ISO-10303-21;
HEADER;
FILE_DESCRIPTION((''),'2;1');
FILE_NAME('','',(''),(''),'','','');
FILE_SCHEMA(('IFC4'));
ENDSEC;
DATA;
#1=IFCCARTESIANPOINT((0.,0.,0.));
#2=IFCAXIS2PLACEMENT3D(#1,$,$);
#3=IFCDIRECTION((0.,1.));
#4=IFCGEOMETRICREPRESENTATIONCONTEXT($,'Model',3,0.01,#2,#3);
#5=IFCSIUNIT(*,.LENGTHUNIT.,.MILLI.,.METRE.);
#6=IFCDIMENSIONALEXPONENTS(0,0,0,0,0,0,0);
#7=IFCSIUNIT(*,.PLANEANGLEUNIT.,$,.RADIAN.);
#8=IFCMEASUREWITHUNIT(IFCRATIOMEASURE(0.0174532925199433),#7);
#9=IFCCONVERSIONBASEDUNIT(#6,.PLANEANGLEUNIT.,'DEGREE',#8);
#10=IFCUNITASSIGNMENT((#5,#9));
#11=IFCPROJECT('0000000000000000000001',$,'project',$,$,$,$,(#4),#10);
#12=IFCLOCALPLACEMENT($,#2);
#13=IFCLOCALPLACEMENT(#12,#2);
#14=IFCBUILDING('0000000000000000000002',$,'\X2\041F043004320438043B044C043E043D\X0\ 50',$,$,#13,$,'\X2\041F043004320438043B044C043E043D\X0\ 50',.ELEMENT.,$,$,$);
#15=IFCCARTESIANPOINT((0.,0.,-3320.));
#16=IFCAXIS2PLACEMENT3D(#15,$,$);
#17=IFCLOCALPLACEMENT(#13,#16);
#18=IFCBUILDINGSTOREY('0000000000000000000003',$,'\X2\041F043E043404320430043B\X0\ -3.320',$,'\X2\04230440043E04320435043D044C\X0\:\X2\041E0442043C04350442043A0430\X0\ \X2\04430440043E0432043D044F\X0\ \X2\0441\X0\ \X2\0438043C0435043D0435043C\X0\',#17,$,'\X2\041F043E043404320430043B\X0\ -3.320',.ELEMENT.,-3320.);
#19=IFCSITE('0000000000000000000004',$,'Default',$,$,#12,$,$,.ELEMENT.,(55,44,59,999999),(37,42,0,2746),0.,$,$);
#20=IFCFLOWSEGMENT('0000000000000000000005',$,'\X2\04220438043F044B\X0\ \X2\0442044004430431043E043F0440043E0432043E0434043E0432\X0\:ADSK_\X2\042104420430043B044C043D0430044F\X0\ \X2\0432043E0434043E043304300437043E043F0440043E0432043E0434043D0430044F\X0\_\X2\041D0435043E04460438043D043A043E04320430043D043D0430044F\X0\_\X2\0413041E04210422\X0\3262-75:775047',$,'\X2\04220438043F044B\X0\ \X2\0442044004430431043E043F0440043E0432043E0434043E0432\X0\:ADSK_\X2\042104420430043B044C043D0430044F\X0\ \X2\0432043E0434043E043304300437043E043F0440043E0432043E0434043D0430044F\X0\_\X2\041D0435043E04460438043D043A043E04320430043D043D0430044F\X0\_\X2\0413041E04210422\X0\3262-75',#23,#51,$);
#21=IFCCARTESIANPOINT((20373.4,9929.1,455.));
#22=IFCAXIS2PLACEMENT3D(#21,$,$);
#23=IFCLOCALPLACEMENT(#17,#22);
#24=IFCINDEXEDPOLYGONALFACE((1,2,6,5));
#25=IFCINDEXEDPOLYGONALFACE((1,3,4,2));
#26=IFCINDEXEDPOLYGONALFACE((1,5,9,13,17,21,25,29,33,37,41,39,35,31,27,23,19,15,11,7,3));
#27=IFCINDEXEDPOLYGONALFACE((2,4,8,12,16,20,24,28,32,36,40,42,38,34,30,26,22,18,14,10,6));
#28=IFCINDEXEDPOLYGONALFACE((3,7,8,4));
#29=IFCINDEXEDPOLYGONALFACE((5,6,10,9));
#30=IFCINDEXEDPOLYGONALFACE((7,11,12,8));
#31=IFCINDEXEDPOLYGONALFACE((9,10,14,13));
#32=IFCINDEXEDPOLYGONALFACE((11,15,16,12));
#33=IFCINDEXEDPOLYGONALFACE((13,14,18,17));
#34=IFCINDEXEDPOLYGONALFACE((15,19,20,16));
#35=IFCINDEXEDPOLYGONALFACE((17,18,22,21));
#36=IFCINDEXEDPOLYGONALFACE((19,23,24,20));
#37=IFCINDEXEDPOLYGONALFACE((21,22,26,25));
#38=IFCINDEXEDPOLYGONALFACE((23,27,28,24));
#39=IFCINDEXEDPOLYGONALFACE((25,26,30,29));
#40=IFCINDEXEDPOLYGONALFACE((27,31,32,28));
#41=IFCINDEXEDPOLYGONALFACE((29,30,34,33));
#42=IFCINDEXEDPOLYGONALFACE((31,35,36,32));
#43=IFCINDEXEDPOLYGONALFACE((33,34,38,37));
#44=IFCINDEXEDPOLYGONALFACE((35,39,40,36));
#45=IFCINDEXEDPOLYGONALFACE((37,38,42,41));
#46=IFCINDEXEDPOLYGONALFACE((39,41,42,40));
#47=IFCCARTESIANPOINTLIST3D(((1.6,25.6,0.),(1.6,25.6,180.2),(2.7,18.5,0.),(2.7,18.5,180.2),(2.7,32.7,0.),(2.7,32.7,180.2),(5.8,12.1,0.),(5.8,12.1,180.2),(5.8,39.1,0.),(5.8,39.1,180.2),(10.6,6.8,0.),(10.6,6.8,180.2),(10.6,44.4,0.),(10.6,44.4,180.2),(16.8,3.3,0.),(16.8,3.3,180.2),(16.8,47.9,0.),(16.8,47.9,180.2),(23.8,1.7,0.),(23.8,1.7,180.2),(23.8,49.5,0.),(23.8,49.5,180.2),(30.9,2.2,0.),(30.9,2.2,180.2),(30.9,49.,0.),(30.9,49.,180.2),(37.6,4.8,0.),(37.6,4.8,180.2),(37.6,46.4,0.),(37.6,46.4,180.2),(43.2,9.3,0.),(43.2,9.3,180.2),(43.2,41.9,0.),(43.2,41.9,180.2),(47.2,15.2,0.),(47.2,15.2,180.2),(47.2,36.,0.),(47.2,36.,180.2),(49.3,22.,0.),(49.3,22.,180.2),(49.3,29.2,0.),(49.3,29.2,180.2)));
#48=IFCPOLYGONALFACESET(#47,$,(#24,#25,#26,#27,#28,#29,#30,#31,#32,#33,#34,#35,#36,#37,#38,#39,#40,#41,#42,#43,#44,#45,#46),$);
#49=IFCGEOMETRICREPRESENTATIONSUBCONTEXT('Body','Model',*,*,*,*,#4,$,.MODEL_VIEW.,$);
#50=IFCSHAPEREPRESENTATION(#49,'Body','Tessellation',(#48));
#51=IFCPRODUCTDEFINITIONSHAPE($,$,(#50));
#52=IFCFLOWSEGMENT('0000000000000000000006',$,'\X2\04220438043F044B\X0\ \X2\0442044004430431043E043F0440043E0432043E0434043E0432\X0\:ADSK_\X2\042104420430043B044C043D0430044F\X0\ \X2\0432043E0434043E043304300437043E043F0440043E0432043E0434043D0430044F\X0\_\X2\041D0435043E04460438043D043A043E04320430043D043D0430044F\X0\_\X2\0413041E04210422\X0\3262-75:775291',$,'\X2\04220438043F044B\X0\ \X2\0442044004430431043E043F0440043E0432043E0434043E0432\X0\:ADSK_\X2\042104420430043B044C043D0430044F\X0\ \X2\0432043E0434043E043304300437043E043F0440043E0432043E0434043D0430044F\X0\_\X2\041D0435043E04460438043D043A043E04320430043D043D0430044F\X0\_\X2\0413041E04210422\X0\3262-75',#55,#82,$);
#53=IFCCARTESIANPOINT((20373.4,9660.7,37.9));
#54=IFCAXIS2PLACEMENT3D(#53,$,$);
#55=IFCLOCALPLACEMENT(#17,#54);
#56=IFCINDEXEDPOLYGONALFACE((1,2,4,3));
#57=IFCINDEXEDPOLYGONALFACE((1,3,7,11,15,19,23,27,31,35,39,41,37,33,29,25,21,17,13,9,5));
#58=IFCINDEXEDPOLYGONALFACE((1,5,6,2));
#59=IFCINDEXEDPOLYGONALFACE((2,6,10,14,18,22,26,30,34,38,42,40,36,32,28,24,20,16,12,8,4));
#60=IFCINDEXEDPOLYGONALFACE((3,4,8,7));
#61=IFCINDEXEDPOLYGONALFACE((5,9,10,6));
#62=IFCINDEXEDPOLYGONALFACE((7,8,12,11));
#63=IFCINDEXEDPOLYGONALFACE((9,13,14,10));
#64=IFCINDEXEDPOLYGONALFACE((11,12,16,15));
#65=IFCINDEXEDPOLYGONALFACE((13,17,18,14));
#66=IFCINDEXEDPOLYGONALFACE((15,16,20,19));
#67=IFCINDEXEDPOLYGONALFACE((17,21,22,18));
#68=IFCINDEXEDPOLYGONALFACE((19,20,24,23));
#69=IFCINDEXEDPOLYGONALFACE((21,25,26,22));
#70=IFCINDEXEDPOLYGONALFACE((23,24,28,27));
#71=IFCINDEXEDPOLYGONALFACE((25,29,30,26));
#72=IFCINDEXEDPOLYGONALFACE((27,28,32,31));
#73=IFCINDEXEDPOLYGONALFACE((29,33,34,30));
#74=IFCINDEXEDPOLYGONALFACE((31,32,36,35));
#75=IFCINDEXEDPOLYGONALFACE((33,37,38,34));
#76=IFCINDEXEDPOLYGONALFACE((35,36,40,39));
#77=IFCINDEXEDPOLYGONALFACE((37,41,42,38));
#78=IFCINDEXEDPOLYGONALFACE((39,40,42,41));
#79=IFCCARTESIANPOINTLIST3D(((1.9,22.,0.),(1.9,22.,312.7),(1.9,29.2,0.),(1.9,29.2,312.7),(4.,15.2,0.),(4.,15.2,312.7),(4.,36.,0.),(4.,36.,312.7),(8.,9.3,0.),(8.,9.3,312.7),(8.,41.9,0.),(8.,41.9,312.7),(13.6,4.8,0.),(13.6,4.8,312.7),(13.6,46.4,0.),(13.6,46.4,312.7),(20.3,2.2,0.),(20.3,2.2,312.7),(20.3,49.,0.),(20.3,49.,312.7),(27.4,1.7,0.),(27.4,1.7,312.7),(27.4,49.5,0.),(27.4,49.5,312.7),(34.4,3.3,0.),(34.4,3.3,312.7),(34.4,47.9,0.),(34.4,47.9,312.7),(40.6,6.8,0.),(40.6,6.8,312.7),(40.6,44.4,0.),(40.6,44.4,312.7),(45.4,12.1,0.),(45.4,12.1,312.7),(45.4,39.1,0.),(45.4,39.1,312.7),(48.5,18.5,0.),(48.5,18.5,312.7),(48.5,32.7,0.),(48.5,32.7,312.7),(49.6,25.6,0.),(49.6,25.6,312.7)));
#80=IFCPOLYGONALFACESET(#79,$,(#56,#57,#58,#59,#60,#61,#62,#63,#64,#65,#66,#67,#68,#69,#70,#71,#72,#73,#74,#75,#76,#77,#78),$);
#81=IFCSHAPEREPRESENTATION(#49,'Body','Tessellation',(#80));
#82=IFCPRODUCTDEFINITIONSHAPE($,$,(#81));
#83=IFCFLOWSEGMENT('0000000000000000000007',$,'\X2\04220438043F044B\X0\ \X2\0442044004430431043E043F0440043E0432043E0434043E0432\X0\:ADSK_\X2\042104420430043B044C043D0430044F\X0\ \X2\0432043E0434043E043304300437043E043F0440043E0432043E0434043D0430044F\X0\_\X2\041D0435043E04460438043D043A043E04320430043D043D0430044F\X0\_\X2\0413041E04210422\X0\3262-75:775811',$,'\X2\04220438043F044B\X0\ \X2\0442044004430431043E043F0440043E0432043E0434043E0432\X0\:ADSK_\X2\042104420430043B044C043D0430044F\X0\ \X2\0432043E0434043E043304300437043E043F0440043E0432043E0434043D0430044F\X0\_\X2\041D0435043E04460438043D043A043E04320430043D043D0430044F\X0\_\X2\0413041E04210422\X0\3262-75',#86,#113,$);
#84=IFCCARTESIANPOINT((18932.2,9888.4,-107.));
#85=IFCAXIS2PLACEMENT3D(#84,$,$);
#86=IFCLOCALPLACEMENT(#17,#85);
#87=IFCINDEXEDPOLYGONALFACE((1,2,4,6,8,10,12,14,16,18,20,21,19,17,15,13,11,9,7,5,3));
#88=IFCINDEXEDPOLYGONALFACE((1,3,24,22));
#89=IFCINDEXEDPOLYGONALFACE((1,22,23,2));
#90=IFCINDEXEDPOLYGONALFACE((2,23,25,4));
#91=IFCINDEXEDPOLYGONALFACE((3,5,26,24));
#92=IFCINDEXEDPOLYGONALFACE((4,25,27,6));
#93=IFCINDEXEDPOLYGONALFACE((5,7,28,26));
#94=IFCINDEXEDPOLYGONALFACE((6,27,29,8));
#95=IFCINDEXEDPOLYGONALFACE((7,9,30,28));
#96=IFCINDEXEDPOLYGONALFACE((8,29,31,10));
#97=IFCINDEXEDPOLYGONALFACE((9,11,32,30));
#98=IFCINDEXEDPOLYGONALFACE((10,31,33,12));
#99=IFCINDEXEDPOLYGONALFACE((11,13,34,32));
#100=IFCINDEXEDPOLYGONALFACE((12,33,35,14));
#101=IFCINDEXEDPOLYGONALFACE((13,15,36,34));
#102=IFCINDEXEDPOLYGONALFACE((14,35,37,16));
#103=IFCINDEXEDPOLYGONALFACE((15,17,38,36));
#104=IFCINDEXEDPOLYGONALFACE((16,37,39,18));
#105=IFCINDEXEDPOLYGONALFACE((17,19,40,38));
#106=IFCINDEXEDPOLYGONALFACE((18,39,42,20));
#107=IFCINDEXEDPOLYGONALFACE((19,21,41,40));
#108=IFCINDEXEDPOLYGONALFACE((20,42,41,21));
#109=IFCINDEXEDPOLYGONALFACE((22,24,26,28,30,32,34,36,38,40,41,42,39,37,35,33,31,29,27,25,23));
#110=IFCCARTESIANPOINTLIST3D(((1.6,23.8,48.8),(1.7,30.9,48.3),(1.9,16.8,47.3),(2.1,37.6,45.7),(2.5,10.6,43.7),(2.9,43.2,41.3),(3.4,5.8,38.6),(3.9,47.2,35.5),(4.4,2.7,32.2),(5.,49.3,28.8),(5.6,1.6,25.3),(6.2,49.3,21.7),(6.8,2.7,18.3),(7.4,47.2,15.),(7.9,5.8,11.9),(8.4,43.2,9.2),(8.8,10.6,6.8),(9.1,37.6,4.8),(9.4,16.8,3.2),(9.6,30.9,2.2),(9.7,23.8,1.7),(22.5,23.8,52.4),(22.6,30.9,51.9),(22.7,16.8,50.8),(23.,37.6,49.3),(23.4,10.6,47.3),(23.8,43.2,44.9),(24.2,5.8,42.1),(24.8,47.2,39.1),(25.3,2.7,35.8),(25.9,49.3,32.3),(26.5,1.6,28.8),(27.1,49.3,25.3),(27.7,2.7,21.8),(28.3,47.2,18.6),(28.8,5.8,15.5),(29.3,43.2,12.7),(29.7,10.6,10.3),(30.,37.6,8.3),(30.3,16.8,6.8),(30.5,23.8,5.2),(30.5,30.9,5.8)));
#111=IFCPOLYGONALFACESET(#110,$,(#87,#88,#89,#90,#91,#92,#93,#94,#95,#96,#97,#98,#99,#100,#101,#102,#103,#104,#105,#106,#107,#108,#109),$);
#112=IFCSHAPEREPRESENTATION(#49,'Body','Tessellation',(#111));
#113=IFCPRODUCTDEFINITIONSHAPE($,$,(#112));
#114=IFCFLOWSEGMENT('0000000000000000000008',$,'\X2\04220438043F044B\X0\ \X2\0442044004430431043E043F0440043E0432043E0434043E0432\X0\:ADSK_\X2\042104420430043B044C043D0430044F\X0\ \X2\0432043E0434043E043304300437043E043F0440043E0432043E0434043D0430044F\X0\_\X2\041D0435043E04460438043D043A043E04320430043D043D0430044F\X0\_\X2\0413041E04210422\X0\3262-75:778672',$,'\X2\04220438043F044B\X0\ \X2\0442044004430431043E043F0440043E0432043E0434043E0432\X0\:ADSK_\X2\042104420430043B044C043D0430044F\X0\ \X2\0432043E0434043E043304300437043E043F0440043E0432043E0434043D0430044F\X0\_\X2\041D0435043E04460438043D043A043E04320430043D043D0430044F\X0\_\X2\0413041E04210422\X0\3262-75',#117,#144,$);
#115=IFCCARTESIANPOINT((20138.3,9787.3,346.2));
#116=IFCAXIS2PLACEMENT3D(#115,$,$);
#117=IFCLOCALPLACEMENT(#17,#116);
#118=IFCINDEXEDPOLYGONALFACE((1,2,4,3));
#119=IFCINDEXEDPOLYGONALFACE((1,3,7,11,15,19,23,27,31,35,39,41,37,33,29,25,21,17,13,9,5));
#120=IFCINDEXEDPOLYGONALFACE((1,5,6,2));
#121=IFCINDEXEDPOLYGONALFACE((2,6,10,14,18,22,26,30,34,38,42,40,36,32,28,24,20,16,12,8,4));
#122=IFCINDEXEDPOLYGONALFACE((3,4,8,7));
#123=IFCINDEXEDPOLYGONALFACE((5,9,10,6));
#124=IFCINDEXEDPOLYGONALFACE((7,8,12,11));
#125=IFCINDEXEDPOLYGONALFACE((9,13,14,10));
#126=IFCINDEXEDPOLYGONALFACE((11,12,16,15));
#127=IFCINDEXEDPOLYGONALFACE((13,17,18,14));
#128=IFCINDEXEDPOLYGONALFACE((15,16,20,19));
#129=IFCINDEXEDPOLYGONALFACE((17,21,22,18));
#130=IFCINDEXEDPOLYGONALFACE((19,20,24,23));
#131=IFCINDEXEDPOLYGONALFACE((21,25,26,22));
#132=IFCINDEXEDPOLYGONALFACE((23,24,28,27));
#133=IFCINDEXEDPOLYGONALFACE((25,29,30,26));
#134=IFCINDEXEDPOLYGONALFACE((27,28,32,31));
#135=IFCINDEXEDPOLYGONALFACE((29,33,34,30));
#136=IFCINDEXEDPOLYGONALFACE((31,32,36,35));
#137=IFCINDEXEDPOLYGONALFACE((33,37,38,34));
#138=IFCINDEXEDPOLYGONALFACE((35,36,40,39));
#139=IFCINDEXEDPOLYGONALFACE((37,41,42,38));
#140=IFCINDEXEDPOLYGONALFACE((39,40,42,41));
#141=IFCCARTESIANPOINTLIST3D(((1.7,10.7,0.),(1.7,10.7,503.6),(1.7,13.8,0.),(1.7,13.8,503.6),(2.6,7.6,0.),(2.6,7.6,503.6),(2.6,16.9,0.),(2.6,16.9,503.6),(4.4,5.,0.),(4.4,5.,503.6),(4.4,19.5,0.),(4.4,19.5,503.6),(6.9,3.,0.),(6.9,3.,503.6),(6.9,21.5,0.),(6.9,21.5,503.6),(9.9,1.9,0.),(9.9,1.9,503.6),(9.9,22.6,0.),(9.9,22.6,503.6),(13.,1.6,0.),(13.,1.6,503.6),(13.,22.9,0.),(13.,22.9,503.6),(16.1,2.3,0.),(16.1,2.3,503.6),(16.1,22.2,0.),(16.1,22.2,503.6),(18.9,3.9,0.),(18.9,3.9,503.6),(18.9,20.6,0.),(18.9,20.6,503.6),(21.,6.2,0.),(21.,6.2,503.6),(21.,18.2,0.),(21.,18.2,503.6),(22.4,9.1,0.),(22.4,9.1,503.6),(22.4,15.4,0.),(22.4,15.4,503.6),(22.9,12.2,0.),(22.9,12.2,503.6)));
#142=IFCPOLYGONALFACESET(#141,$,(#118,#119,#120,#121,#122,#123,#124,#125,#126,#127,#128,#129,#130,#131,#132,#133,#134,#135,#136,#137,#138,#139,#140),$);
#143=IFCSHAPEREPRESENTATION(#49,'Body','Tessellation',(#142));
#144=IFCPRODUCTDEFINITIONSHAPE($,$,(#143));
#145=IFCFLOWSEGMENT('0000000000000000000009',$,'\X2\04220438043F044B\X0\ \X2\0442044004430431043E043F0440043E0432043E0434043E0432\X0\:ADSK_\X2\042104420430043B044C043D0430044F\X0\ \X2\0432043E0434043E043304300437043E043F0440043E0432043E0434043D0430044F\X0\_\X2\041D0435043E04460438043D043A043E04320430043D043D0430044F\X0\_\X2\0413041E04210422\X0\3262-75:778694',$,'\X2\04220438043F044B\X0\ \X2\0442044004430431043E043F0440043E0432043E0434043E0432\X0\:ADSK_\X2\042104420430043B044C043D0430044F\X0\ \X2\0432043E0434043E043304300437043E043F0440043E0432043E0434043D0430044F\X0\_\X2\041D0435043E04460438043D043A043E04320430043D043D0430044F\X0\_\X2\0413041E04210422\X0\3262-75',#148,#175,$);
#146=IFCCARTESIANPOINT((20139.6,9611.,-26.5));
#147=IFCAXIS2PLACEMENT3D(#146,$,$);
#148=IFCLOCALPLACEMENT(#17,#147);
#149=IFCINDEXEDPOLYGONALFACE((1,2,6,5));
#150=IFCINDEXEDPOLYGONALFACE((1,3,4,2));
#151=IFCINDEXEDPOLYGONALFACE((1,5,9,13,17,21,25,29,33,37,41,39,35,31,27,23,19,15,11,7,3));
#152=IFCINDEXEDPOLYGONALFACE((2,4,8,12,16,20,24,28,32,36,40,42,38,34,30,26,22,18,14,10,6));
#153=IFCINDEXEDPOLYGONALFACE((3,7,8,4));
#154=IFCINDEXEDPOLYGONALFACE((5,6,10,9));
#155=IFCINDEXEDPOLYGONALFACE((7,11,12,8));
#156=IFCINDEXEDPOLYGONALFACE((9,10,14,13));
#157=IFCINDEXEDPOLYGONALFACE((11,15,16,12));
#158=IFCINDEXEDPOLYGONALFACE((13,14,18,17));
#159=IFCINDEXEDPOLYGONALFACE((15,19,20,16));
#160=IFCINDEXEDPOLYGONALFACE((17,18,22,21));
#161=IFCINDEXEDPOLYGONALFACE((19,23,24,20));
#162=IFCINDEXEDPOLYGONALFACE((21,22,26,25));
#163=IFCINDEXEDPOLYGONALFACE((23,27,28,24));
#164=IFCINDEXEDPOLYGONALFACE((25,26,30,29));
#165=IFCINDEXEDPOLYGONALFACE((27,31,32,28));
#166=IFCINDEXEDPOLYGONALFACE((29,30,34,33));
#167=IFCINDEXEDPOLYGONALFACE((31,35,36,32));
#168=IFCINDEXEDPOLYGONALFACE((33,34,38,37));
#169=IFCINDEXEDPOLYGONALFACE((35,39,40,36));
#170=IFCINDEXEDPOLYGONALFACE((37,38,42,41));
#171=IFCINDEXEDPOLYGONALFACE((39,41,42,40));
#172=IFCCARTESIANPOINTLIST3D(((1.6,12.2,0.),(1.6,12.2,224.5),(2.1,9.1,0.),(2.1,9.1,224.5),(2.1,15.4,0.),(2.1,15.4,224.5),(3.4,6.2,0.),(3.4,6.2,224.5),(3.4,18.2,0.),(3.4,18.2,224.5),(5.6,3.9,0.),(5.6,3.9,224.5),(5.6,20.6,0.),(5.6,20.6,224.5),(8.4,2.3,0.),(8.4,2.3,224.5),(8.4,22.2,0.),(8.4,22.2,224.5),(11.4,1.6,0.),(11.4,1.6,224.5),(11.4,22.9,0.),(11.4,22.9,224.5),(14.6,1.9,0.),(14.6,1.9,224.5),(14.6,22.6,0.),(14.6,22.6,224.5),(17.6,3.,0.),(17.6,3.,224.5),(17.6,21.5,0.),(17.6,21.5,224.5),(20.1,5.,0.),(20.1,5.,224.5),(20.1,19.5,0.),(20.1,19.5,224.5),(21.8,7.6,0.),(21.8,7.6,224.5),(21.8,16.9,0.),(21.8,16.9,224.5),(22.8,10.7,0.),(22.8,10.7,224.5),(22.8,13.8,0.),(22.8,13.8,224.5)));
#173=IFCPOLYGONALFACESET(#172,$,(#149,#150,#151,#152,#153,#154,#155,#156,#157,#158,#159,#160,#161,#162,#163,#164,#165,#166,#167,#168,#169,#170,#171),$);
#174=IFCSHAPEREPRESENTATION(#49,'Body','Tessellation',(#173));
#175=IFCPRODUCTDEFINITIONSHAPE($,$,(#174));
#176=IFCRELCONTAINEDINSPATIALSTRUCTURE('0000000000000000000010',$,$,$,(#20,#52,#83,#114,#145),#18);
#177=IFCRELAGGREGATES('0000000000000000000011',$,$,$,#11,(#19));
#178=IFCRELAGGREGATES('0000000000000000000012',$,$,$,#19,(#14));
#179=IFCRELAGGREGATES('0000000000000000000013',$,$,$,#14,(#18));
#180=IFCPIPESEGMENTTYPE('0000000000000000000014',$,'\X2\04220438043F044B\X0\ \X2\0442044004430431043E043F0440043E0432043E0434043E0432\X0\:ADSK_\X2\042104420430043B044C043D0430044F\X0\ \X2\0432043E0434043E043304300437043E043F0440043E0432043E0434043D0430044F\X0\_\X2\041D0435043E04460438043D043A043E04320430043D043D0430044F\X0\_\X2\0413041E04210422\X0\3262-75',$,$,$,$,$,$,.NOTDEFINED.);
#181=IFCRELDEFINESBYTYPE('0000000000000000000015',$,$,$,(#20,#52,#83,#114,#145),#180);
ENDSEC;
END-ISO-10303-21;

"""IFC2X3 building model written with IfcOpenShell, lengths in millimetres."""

from ifc_helpers import new_model, entity, si_unit, converted_unit, direction, frame, frame_2d, origin, origin_2d_with_axis, place, context, subcontext, project, spatial, circle, extrude, type_object, element, save


model = new_model("IFC2X3")

# Units and contexts
model_context = context("Model", 3, precision=0.01, world=origin(), true_north=direction((0.0, 1.0)))
body_context = subcontext(model_context, "Body", "Model", "MODEL_VIEW")
ifc_project = project(units=[si_unit("LENGTHUNIT", "METRE", prefix="MILLI"), converted_unit("PLANEANGLEUNIT", "DEGREE", entity("IfcRatioMeasure", 0.0174532925199433), si_unit("PLANEANGLEUNIT", "RADIAN"), dimensions=[0, 0, 0, 0, 0, 0, 0])], contexts=[model_context])

# Site, building, storey
site_placement = place(None, origin())
site = spatial("IfcSite", under=ifc_project, at=site_placement, Name="Default", CompositionType="ELEMENT", RefLatitude=(55, 44, 59, 999999), RefLongitude=(37, 42, 0, 2746), RefElevation=0.0)
building_placement = place(site_placement, origin())
building = spatial("IfcBuilding", under=site, at=building_placement, Name="Павильон 50", LongName="Павильон 50", CompositionType="ELEMENT")
storey_placement = place(building_placement, frame((0.0, 0.0, -3320.0)))
storey = spatial("IfcBuildingStorey", under=building, at=storey_placement, Name="Подвал -3.320", ObjectType="Уровень:Отметка уровня с именем", LongName="Подвал -3.320", CompositionType="ELEMENT", Elevation=-3320.0)

# Flow segments
pipe_segment_type = type_object("IfcPipeSegmentType", Name="Типы трубопроводов:ADSK_Стальная водогазопроводная_Неоцинкованная_ГОСТ3262-75", PredefinedType="NOTDEFINED")
flow_segment_1_placement = place(storey_placement, frame((20373.4, 9929.1, 455.0)))
element("IfcFlowSegment", 1, at=flow_segment_1_placement, inside=storey, type_object=pipe_segment_type, Name="Типы трубопроводов:ADSK_Стальная водогазопроводная_Неоцинкованная_ГОСТ3262-75:775047", ObjectType="Типы трубопроводов:ADSK_Стальная водогазопроводная_Неоцинкованная_ГОСТ3262-75", context=body_context, shape_type="SweptSolid", body=[
    extrude(circle(Radius=24.0, at=origin_2d_with_axis()), frame((25.6, 25.6, 0.0), z_axis=(0.0, 0.0, 1.0), x_axis=(-1.0, 0.0, 0.0)), (0.0, 0.0, 1.0), 180.2),
])
flow_segment_2_placement = place(storey_placement, frame((20373.4, 9660.7, 37.9)))
element("IfcFlowSegment", 2, at=flow_segment_2_placement, inside=storey, type_object=pipe_segment_type, Name="Типы трубопроводов:ADSK_Стальная водогазопроводная_Неоцинкованная_ГОСТ3262-75:775291", ObjectType="Типы трубопроводов:ADSK_Стальная водогазопроводная_Неоцинкованная_ГОСТ3262-75", context=body_context, shape_type="SweptSolid", body=[
    extrude(circle(Radius=24.0, at=origin_2d_with_axis()), frame((25.6, 25.6, 0.0)), (0.0, 0.0, 1.0), 312.7),
])
flow_segment_3_placement = place(storey_placement, frame((18932.2, 9888.4, -107.0)))
element("IfcFlowSegment", 3, at=flow_segment_3_placement, inside=storey, type_object=pipe_segment_type, Name="Типы трубопроводов:ADSK_Стальная водогазопроводная_Неоцинкованная_ГОСТ3262-75:775811", ObjectType="Типы трубопроводов:ADSK_Стальная водогазопроводная_Неоцинкованная_ГОСТ3262-75", context=body_context, shape_type="SweptSolid", body=[
    extrude(circle(Radius=24.0, at=frame_2d((0.0, 0.0), x_axis=(1.0, 0.0))), frame((5.6, 25.6, 25.3), z_axis=(0.985692, 0.0, 0.168556), x_axis=(0.0, -1.0, 0.0)), (0.0, 0.0, 1.0), 21.2),
])
flow_segment_4_placement = place(storey_placement, frame((20138.3, 9787.3, 346.2)))
element("IfcFlowSegment", 4, at=flow_segment_4_placement, inside=storey, type_object=pipe_segment_type, Name="Типы трубопроводов:ADSK_Стальная водогазопроводная_Неоцинкованная_ГОСТ3262-75:778672", ObjectType="Типы трубопроводов:ADSK_Стальная водогазопроводная_Неоцинкованная_ГОСТ3262-75", context=body_context, shape_type="SweptSolid", body=[
    extrude(circle(Radius=10.7, at=origin_2d_with_axis()), frame((12.2, 12.2, 0.0)), (0.0, 0.0, 1.0), 503.6),
])
flow_segment_5_placement = place(storey_placement, frame((20139.6, 9611.0, -26.5)))
element("IfcFlowSegment", 5, at=flow_segment_5_placement, inside=storey, type_object=pipe_segment_type, Name="Типы трубопроводов:ADSK_Стальная водогазопроводная_Неоцинкованная_ГОСТ3262-75:778694", ObjectType="Типы трубопроводов:ADSK_Стальная водогазопроводная_Неоцинкованная_ГОСТ3262-75", context=body_context, shape_type="SweptSolid", body=[
    extrude(circle(Radius=10.7, at=origin_2d_with_axis()), frame((12.2, 12.2, 0.0), z_axis=(0.0, 0.0, 1.0), x_axis=(-1.0, 0.0, 0.0)), (0.0, 0.0, 1.0), 224.5),
])

save(model, "model.ifc")
